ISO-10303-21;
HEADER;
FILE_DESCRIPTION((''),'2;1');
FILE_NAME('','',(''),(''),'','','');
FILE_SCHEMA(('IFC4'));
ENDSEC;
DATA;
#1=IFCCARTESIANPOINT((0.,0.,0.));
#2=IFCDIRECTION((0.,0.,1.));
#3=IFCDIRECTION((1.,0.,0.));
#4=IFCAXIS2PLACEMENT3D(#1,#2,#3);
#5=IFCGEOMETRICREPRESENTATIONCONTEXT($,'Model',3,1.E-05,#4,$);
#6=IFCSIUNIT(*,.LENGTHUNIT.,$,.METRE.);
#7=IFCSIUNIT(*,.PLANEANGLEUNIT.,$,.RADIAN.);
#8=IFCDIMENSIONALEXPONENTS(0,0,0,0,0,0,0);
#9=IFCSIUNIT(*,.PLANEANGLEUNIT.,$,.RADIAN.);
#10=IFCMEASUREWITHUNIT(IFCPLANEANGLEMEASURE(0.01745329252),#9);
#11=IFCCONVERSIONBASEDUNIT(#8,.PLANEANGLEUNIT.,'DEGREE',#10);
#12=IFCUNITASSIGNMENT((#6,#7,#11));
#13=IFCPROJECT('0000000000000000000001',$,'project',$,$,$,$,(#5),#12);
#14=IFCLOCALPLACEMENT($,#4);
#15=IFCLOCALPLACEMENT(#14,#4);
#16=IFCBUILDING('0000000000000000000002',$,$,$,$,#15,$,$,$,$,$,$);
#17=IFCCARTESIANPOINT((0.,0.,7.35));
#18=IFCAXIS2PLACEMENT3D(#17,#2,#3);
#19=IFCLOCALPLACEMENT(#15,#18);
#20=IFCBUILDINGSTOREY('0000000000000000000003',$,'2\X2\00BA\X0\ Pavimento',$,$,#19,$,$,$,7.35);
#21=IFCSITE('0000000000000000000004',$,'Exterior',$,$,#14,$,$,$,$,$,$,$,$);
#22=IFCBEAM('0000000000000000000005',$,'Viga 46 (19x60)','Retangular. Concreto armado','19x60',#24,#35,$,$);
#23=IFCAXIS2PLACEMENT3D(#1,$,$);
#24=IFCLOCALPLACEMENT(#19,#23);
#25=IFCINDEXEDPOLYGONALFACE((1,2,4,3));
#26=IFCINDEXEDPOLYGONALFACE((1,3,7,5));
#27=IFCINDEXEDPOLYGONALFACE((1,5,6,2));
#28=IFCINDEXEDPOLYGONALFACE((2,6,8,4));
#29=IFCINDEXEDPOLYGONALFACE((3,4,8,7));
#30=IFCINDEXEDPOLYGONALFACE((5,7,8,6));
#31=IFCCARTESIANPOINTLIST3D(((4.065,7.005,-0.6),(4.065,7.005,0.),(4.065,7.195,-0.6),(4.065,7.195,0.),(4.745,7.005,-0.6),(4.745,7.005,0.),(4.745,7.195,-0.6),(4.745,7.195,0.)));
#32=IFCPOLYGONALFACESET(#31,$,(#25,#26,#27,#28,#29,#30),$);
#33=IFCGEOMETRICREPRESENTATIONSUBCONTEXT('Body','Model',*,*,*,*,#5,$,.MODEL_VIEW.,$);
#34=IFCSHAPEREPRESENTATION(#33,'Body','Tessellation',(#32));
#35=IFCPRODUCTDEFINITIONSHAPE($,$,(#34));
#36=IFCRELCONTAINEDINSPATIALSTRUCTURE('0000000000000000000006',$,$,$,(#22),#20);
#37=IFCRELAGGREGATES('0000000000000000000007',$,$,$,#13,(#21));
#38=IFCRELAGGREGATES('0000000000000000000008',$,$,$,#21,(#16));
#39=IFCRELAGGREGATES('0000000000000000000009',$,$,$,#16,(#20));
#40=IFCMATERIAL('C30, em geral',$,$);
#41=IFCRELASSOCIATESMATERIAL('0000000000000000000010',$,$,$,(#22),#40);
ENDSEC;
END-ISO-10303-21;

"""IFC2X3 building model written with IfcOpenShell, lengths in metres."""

from ifc_helpers import new_model, entity, si_unit, converted_unit, frame, frame_2d, origin_with_axes, place, context, subcontext, project, spatial, rectangle, extrude, material, element, save


model = new_model("IFC2X3")

# Units and contexts
model_context = context("Model", 3, precision=1e-05, world=origin_with_axes())
body_context = subcontext(model_context, "Body", "Model", "MODEL_VIEW")
ifc_project = project(units=[si_unit("LENGTHUNIT", "METRE"), si_unit("PLANEANGLEUNIT", "RADIAN"), converted_unit("PLANEANGLEUNIT", "DEGREE", entity("IfcPlaneAngleMeasure", 0.01745329252), si_unit("PLANEANGLEUNIT", "RADIAN"), dimensions=[0, 0, 0, 0, 0, 0, 0])], contexts=[model_context])

# Site, building, storey
site_placement = place(None, origin_with_axes())
site = spatial("IfcSite", under=ifc_project, at=site_placement, Name="Exterior")
building_placement = place(site_placement, origin_with_axes())
building = spatial("IfcBuilding", under=site, at=building_placement)
storey_placement = place(building_placement, frame((0.0, 0.0, 7.35), z_axis=(0.0, 0.0, 1.0), x_axis=(1.0, 0.0, 0.0)))
storey = spatial("IfcBuildingStorey", under=building, at=storey_placement, Name="2º Pavimento", Elevation=7.35)

# Beam
ifc_material = material(Name="C30, em geral")
beam_1_placement = place(storey_placement, frame((4.065, 7.1, 0.0), z_axis=(1.0, 0.0, 0.0), x_axis=(0.0, 1.0, 0.0)))
element("IfcBeam", 1, at=beam_1_placement, inside=storey, material=ifc_material, Name="Viga 46 (19x60)", Description="Retangular. Concreto armado", ObjectType="19x60", context=body_context, shape_type="SweptSolid", body=[
    extrude(rectangle(XDim=0.19, YDim=0.6, at=frame_2d((0.0, -0.3), x_axis=(1.0, 0.0))), origin_with_axes(), (0.0, 0.0, 1.0), 0.68),
])

save(model, "model.ifc")
